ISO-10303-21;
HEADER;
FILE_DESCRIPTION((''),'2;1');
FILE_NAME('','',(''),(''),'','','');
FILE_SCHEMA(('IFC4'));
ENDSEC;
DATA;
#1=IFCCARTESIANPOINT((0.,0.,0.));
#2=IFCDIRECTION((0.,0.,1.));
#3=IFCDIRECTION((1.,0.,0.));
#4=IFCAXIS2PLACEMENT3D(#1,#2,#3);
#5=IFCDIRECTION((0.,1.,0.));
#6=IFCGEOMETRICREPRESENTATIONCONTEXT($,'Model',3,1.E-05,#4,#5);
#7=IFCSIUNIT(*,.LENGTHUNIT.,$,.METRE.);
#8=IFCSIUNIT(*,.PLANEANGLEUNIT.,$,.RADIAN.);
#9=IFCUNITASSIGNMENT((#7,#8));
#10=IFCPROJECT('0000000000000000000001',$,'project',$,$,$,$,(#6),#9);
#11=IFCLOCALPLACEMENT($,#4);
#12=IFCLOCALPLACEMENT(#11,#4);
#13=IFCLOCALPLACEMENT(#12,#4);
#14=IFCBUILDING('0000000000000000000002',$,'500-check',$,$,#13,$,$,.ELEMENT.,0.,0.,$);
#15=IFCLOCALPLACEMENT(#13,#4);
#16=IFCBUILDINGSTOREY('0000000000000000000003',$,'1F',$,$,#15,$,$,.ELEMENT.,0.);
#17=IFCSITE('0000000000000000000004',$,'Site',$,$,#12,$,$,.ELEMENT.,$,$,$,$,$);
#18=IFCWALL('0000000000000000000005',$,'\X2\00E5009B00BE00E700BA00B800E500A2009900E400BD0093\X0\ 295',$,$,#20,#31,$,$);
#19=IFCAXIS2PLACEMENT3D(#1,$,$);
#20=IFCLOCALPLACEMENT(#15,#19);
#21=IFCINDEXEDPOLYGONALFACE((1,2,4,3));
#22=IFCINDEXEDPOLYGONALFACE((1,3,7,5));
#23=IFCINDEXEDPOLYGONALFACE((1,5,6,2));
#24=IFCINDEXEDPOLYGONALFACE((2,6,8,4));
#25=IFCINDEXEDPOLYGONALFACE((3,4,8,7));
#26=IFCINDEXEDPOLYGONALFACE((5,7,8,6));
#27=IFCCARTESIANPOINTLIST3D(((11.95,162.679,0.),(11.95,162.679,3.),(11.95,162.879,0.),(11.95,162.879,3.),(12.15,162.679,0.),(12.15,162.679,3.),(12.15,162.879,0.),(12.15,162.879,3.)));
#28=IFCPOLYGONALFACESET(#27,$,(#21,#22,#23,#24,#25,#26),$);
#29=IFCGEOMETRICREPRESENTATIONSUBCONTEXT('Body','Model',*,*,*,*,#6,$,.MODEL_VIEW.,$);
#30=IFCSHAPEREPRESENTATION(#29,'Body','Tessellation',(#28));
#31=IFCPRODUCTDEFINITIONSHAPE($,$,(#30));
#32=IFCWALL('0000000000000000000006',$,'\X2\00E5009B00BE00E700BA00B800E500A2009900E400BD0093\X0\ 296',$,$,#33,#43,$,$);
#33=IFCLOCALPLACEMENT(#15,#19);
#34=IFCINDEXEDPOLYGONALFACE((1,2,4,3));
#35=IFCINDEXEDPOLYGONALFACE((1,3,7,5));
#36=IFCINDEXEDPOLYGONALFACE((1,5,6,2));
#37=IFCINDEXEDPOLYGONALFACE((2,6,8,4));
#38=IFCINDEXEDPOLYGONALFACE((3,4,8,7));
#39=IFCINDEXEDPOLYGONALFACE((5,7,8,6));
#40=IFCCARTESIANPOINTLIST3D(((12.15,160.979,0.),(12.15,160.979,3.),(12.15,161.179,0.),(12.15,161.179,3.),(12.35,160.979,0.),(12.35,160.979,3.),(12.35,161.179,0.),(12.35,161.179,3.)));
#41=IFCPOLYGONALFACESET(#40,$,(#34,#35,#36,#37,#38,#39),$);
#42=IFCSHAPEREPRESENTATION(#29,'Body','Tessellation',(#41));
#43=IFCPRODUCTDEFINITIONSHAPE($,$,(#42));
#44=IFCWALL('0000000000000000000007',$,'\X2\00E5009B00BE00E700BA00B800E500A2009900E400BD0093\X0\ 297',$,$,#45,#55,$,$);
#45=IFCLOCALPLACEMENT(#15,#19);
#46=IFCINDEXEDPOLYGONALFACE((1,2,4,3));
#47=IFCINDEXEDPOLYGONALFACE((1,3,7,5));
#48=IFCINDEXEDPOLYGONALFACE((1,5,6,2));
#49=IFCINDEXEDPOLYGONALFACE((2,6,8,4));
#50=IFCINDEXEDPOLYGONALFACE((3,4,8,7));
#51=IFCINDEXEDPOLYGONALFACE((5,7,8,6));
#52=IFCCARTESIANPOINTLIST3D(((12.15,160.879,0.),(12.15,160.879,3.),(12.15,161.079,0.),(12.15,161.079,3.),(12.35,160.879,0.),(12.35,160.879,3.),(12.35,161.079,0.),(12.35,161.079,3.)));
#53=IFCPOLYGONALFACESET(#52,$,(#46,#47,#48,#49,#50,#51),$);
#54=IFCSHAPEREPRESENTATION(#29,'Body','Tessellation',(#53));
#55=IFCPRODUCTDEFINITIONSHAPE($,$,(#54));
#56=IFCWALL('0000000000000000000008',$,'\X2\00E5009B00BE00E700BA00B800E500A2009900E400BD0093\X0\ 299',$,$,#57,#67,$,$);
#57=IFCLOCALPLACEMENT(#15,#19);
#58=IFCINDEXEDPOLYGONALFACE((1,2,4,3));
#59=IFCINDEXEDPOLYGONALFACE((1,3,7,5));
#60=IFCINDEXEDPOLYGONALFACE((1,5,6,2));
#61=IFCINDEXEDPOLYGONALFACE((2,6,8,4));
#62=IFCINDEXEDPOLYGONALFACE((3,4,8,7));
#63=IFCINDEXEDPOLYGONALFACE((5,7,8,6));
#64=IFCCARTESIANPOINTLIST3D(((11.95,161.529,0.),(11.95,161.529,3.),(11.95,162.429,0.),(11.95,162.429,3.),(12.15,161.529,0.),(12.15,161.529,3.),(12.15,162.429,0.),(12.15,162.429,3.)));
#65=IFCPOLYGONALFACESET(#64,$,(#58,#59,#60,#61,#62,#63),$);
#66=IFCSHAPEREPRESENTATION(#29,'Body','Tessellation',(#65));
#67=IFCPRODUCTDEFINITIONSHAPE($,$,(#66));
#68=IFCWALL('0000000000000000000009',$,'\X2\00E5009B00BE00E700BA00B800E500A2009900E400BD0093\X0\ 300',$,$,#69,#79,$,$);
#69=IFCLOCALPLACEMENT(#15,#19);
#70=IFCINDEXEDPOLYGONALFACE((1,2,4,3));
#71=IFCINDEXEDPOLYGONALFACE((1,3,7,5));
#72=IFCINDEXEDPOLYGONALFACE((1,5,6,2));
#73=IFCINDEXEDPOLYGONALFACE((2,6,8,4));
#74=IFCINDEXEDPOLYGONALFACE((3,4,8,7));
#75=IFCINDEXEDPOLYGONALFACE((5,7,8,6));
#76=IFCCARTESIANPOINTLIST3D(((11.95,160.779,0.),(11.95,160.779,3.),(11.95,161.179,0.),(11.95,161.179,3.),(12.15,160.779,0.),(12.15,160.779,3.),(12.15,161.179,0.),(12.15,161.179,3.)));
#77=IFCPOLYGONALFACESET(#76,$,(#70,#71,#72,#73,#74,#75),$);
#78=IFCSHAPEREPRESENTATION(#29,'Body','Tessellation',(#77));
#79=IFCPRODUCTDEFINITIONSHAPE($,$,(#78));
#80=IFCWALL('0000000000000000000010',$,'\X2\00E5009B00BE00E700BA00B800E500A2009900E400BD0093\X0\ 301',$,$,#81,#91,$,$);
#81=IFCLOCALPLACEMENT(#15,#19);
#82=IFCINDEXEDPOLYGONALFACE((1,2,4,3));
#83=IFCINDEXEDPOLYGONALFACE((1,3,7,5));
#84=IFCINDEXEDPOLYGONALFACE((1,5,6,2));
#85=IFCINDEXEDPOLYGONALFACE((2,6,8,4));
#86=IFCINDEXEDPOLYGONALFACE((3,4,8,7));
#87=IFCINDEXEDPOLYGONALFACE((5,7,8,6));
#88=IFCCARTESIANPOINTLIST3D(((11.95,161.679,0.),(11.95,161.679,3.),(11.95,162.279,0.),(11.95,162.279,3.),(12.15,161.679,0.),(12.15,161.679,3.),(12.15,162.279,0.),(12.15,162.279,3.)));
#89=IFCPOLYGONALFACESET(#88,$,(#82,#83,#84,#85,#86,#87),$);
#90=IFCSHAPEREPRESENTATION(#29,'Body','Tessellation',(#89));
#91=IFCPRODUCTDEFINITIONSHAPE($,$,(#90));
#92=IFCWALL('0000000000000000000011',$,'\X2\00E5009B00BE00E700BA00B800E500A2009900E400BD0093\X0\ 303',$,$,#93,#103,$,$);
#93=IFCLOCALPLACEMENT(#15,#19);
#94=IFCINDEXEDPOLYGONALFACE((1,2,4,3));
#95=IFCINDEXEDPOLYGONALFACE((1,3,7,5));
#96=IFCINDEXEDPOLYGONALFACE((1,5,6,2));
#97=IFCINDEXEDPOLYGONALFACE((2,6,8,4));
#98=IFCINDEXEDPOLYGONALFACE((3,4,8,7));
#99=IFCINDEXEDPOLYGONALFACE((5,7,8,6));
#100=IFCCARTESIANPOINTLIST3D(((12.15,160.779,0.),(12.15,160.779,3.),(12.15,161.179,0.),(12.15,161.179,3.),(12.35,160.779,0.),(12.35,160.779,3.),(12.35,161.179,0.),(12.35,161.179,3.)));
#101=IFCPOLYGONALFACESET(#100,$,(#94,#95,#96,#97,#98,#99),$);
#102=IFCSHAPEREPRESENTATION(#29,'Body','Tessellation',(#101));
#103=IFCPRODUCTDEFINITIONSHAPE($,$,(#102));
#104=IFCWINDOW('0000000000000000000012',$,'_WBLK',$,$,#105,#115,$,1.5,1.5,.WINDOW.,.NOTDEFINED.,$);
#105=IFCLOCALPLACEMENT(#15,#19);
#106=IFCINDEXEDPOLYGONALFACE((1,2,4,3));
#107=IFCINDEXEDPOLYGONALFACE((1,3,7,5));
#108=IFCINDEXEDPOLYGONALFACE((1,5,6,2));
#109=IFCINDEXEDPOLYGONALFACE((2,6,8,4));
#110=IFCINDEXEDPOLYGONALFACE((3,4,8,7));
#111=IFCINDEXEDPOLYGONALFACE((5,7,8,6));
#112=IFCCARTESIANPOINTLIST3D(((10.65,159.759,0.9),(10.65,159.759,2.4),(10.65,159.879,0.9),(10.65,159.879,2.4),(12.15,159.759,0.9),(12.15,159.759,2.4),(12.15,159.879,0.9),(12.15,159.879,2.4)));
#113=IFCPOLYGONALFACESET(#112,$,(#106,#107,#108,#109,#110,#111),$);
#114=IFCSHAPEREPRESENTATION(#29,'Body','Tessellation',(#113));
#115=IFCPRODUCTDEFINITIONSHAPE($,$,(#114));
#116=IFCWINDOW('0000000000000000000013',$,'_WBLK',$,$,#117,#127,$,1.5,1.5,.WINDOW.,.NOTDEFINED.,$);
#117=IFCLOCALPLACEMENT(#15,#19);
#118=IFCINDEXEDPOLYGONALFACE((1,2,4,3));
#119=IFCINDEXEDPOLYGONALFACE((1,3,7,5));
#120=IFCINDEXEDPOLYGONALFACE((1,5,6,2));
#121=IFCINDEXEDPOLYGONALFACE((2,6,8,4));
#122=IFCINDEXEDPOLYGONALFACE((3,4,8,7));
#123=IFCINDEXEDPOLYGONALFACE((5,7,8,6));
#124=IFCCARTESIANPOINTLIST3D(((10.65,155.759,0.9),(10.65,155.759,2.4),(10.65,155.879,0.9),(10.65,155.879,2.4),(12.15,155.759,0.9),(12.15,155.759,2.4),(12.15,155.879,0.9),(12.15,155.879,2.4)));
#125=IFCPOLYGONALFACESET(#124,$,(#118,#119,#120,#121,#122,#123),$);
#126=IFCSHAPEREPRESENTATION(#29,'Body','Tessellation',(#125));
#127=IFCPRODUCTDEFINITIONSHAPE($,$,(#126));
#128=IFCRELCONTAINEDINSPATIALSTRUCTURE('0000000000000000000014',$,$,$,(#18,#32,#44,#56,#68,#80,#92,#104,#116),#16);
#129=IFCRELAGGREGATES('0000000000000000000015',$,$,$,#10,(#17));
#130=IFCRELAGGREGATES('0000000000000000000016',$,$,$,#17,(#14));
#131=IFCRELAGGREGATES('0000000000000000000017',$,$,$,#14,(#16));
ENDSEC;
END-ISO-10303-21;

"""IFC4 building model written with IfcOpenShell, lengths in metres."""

from ifc_helpers import new_model, si_unit, direction, frame, frame_2d, origin_with_axes, place, context, subcontext, project, spatial, rectangle, extrude, element, save


model = new_model("IFC4")

# Units and contexts
model_context = context("Model", 3, precision=1e-05, world=origin_with_axes(), true_north=direction((0.0, 1.0, 0.0)))
body_context = subcontext(model_context, "Body", "Model", "MODEL_VIEW")
ifc_project = project(units=[si_unit("LENGTHUNIT", "METRE"), si_unit("PLANEANGLEUNIT", "RADIAN")], contexts=[model_context])

# Site, building, storey
placement = place(None, origin_with_axes())
site_placement = place(placement, origin_with_axes())
site = spatial("IfcSite", under=ifc_project, at=site_placement, Name="Site", CompositionType="ELEMENT")
building_placement = place(site_placement, origin_with_axes())
building = spatial("IfcBuilding", under=site, at=building_placement, Name="500-check", CompositionType="ELEMENT", ElevationOfRefHeight=0.0, ElevationOfTerrain=0.0)
storey_placement = place(building_placement, origin_with_axes())
storey = spatial("IfcBuildingStorey", under=building, at=storey_placement, Name="1F", CompositionType="ELEMENT", Elevation=0.0)

# Walls
for number, where, z_axis, x_axis, name in (
    (1, (12.05, 162.779, 0.0), (0.0, 0.0, 1.0), (1.0, 0.0, 0.0), "å\u009b¾çº¸å¢\u0099ä½\u0093 295"),
    (2, (12.25, 161.079, 0.0), (0.0, 0.0, 1.0), (-1.0, 0.0, 0.0), "å\u009b¾çº¸å¢\u0099ä½\u0093 296"),
    (3, (12.25, 160.979, 0.0), (0.0, 0.0, 1.0), (-1.0, 0.0, 0.0), "å\u009b¾çº¸å¢\u0099ä½\u0093 297"),
):
    element("IfcWall", number, at=place(storey_placement, frame(where, z_axis=z_axis, x_axis=x_axis)), inside=storey, Name=name, context=body_context, shape_type="SweptSolid", body=[
        extrude(rectangle(XDim=0.2, YDim=0.2, at=frame_2d((0.0, 0.0), x_axis=(1.0, 0.0, 0.0))), frame((0.0, 0.0, 0.0), z_axis=(0.0, 0.0, 1.0)), (0.0, 0.0, 1.0), 3.0),
    ])
wall_1_placement = place(storey_placement, frame((12.05, 161.979, 0.0), z_axis=(0.0, 0.0, 1.0), x_axis=(0.0, 1.0, 0.0)))
element("IfcWall", 4, at=wall_1_placement, inside=storey, Name="å\u009b¾çº¸å¢\u0099ä½\u0093 299", context=body_context, shape_type="SweptSolid", body=[
    extrude(rectangle(XDim=0.9, YDim=0.2, at=frame_2d((0.0, 0.0), x_axis=(1.0, 0.0, 0.0))), frame((0.0, 0.0, 0.0), z_axis=(0.0, 0.0, 1.0)), (0.0, 0.0, 1.0), 3.0),
])
wall_2_placement = place(storey_placement, frame((12.05, 160.979, 0.0), z_axis=(0.0, 0.0, 1.0), x_axis=(0.0, 1.0, 0.0)))
element("IfcWall", 5, at=wall_2_placement, inside=storey, Name="å\u009b¾çº¸å¢\u0099ä½\u0093 300", context=body_context, shape_type="SweptSolid", body=[
    extrude(rectangle(XDim=0.4, YDim=0.2, at=frame_2d((0.0, 0.0), x_axis=(1.0, 0.0, 0.0))), frame((0.0, 0.0, 0.0), z_axis=(0.0, 0.0, 1.0)), (0.0, 0.0, 1.0), 3.0),
])
wall_3_placement = place(storey_placement, frame((12.05, 161.979, 0.0), z_axis=(0.0, 0.0, 1.0), x_axis=(0.0, -1.0, 0.0)))
element("IfcWall", 6, at=wall_3_placement, inside=storey, Name="å\u009b¾çº¸å¢\u0099ä½\u0093 301", context=body_context, shape_type="SweptSolid", body=[
    extrude(rectangle(XDim=0.6, YDim=0.2, at=frame_2d((0.0, 0.0), x_axis=(1.0, 0.0, 0.0))), frame((0.0, 0.0, 0.0), z_axis=(0.0, 0.0, 1.0)), (0.0, 0.0, 1.0), 3.0),
])
wall_4_placement = place(storey_placement, frame((12.25, 160.979, 0.0), z_axis=(0.0, 0.0, 1.0), x_axis=(0.0, 1.0, 0.0)))
element("IfcWall", 7, at=wall_4_placement, inside=storey, Name="å\u009b¾çº¸å¢\u0099ä½\u0093 303", context=body_context, shape_type="SweptSolid", body=[
    extrude(rectangle(XDim=0.4, YDim=0.2, at=frame_2d((0.0, 0.0), x_axis=(1.0, 0.0, 0.0))), frame((0.0, 0.0, 0.0), z_axis=(0.0, 0.0, 1.0)), (0.0, 0.0, 1.0), 3.0),
])

# Windows
for number, where, z_axis, x_axis, name in (
    (8, (11.4, 159.819, 0.9), (0.0, 0.0, 1.0), (1.0, 0.0, 0.0), "_WBLK"),
    (9, (11.4, 155.819, 0.9), (0.0, 0.0, 1.0), (1.0, 0.0, 0.0), "_WBLK"),
):
    element("IfcWindow", number, at=place(storey_placement, frame(where, z_axis=z_axis, x_axis=x_axis)), inside=storey, Name=name, OverallHeight=1.5, OverallWidth=1.5, PartitioningType="NOTDEFINED", PredefinedType="WINDOW", context=body_context, shape_type="SweptSolid", body=[
        extrude(rectangle(XDim=1.5, YDim=0.12, at=frame_2d((0.0, 0.0), x_axis=(1.0, 0.0, 0.0))), frame((0.0, 0.0, 0.0), z_axis=(0.0, 0.0, 1.0)), (0.0, 0.0, 1.0), 1.5),
    ])

save(model, "model.ifc")
